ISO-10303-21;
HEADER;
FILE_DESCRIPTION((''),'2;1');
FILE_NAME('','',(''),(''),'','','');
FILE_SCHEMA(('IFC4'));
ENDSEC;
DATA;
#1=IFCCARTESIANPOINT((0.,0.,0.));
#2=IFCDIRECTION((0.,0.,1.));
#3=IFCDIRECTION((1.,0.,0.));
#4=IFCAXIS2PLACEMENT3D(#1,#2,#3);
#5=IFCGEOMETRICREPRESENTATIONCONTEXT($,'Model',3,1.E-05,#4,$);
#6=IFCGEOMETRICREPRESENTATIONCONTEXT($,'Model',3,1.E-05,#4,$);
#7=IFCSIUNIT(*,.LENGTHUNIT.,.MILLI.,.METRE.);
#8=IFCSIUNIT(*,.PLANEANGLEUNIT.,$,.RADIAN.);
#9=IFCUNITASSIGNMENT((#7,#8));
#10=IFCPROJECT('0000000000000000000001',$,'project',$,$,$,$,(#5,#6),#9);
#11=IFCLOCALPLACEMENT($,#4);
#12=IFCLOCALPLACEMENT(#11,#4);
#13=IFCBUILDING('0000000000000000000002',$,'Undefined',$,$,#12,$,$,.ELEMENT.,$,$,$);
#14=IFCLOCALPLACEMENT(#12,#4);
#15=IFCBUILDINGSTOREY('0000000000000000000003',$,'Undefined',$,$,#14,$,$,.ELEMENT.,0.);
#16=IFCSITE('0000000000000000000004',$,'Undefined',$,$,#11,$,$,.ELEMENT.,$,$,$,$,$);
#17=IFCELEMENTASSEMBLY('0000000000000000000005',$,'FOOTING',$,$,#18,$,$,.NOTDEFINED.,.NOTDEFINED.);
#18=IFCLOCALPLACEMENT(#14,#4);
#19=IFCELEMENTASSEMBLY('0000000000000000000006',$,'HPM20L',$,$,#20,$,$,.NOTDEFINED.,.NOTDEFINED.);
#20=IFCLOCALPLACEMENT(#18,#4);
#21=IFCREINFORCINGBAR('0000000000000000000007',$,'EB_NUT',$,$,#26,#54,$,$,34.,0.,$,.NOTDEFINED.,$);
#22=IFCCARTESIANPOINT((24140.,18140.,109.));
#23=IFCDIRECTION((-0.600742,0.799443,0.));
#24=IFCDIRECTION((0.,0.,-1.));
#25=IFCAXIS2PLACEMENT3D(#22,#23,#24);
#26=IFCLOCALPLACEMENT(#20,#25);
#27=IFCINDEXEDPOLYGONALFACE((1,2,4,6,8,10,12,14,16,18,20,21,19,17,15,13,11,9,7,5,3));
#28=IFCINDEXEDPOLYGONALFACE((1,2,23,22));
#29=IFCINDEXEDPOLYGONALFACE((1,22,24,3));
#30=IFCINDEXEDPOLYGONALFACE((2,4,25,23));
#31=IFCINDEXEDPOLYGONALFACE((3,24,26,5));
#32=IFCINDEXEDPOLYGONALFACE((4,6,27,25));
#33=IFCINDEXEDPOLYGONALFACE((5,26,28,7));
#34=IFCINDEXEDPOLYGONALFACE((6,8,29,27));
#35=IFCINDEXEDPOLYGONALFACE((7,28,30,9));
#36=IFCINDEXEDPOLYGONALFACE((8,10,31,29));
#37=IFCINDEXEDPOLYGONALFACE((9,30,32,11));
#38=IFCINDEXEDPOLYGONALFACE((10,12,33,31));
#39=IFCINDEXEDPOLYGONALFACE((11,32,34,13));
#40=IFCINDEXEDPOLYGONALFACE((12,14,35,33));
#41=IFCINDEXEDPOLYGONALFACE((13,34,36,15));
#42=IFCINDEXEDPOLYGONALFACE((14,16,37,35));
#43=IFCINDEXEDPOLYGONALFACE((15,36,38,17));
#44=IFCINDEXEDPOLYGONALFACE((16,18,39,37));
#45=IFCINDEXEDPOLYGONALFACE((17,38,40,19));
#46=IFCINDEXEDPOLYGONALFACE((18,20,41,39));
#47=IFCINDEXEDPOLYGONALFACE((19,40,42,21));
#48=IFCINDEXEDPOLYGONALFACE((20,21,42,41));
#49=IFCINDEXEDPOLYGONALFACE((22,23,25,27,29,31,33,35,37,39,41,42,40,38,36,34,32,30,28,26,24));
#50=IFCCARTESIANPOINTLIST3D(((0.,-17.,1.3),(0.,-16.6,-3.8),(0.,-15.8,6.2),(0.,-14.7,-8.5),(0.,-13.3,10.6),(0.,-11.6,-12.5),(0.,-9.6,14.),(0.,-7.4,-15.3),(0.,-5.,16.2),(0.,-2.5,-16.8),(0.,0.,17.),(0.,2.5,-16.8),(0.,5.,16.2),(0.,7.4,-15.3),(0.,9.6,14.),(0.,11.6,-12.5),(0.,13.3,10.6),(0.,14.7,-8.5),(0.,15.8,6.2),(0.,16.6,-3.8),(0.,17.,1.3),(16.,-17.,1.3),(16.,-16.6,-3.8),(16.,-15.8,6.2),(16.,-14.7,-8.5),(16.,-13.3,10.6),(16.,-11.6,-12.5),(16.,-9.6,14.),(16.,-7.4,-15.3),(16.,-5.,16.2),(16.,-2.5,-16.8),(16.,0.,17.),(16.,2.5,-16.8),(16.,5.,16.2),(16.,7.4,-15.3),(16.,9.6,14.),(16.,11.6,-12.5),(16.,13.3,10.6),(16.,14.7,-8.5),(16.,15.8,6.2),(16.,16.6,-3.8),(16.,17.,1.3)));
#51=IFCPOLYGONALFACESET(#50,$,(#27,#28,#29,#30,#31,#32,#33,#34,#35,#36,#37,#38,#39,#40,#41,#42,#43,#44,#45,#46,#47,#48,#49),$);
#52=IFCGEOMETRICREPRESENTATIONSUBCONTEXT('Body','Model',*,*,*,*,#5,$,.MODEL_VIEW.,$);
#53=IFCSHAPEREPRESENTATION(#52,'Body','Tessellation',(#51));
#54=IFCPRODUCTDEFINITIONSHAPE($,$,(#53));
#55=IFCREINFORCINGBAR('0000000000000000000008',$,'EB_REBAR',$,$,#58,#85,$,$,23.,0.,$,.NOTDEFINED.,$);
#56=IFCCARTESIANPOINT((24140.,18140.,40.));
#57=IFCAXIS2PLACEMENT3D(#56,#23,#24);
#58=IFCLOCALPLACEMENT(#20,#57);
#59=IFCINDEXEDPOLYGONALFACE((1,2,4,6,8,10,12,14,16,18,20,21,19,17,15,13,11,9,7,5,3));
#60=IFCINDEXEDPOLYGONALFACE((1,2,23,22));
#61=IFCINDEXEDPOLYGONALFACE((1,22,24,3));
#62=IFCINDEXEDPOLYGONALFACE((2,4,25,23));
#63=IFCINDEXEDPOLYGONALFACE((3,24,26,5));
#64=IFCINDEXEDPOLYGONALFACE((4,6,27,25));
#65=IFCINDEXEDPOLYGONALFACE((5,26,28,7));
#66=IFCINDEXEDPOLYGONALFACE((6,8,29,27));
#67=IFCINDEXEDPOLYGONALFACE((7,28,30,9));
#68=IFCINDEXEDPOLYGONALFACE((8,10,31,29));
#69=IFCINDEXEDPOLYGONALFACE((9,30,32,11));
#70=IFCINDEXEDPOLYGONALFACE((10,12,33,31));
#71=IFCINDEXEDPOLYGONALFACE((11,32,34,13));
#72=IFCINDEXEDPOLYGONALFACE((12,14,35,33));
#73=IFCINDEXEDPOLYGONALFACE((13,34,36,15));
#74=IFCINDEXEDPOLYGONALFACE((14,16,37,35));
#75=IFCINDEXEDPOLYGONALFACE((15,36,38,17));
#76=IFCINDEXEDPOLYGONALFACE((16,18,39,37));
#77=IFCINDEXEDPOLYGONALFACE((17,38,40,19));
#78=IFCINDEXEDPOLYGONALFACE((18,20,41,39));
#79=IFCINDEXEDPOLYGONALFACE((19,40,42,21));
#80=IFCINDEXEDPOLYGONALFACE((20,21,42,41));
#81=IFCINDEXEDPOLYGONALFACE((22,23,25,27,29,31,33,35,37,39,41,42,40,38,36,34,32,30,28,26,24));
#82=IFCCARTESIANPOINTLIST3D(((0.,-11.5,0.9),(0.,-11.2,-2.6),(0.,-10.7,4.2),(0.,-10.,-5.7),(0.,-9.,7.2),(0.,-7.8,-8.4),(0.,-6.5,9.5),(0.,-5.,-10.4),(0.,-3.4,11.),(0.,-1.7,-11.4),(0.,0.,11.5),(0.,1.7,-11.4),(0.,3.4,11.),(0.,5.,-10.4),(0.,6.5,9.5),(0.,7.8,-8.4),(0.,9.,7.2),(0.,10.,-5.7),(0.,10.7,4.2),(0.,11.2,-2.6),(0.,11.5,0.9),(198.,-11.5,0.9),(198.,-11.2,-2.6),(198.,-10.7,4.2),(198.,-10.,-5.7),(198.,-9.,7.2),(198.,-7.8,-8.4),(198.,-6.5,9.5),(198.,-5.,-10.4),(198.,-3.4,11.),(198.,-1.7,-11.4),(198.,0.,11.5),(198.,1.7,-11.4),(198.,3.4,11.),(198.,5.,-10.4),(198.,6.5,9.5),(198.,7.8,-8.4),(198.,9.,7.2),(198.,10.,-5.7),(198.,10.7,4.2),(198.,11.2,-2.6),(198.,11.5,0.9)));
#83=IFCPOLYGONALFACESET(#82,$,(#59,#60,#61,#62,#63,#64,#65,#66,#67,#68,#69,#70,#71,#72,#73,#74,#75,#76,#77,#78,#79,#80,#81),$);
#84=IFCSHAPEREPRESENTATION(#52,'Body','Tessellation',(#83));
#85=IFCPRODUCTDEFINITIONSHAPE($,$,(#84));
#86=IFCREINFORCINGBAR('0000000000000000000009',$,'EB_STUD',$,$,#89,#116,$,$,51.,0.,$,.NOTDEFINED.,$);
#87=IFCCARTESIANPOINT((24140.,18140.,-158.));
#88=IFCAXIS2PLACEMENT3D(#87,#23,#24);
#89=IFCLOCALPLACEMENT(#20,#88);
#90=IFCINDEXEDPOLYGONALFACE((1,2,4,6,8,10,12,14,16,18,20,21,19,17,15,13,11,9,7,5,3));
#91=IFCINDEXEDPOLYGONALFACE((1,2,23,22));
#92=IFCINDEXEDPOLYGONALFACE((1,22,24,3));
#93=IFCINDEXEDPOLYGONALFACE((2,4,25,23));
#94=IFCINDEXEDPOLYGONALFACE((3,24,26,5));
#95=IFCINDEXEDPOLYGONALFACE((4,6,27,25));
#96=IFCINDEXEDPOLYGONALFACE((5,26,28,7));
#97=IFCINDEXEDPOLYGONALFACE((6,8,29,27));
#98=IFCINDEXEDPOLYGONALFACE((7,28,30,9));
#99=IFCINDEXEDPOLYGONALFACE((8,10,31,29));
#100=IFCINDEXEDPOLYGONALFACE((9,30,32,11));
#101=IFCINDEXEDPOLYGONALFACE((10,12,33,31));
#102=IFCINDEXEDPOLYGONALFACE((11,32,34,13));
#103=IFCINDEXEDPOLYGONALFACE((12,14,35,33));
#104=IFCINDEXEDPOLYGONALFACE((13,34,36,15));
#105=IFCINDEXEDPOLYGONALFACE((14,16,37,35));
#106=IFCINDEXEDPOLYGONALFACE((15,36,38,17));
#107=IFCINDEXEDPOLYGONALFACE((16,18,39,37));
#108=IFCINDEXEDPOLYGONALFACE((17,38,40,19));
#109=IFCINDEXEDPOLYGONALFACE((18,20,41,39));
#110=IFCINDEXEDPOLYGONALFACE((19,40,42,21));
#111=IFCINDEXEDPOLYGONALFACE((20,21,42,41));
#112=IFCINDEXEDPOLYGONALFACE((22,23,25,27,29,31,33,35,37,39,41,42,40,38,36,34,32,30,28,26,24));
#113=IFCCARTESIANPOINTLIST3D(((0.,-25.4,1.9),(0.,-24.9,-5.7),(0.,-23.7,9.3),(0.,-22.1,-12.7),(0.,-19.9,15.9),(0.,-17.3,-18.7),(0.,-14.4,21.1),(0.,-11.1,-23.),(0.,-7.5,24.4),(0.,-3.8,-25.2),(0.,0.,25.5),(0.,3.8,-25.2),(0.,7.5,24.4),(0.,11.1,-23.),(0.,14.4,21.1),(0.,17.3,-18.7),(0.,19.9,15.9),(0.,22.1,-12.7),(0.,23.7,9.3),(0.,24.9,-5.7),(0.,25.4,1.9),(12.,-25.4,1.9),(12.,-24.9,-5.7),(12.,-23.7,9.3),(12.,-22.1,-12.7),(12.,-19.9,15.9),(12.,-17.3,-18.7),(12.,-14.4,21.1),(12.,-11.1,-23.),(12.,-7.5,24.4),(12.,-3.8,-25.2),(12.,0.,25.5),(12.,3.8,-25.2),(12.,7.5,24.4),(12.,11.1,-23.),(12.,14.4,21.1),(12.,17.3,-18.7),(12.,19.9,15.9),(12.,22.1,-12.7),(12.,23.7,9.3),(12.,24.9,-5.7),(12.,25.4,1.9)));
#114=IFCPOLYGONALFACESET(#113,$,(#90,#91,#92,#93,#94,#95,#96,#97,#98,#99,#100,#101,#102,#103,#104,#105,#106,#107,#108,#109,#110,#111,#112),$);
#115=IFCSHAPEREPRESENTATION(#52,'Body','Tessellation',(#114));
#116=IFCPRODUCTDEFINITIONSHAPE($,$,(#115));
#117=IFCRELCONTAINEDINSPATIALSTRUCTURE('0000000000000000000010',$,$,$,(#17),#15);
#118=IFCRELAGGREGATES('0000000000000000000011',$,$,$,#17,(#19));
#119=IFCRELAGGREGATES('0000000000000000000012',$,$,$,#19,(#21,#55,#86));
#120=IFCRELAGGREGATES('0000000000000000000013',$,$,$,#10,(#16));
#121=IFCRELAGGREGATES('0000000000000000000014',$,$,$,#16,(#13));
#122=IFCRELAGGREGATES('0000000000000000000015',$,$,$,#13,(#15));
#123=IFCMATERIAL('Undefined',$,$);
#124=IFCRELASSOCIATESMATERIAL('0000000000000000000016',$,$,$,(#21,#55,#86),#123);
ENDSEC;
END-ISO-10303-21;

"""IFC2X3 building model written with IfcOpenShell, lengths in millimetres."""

from ifc_helpers import new_model, entity, si_unit, frame, origin_with_axes, place, context, subcontext, project, spatial, source, transform, mapped, material, element, aggregate, save


model = new_model("IFC2X3")

# Units and contexts
model_context_1 = context("Model", 3, precision=1e-05, world=origin_with_axes())
model_context_2 = context("Model", 3, precision=1e-05, world=origin_with_axes())
body_context = subcontext(model_context_1, "Body", "Model", "MODEL_VIEW")
ifc_project = project(units=[si_unit("LENGTHUNIT", "METRE", prefix="MILLI"), si_unit("PLANEANGLEUNIT", "RADIAN")], contexts=[model_context_1, model_context_2])

# Site, building, storey
site_placement = place(None, origin_with_axes())
site = spatial("IfcSite", under=ifc_project, at=site_placement, Name="Undefined", CompositionType="ELEMENT")
building_placement = place(site_placement, origin_with_axes())
building = spatial("IfcBuilding", under=site, at=building_placement, Name="Undefined", CompositionType="ELEMENT")
storey_placement = place(building_placement, origin_with_axes())
storey = spatial("IfcBuildingStorey", under=building, at=storey_placement, Name="Undefined", CompositionType="ELEMENT", Elevation=0.0)

# Element assembly
assembly_1_placement = place(storey_placement, origin_with_axes())
assembly_1 = element("IfcElementAssembly", 1, at=assembly_1_placement, inside=storey, Name="FOOTING", AssemblyPlace="NOTDEFINED", PredefinedType="NOTDEFINED")

# Shared definitions
ifc_material_1 = material(Name="Undefined")

# Element assembly
assembly_2_placement = place(assembly_1_placement, origin_with_axes())
assembly_2 = element("IfcElementAssembly", 2, at=assembly_2_placement, Name="HPM20L", AssemblyPlace="NOTDEFINED", PredefinedType="NOTDEFINED")
aggregate(assembly_1, [assembly_2])

# Reinforcing bars
shared_shape_1 = source(origin_with_axes(), body_context, "Body", "AdvancedSweptSolid", [
    entity("IfcSweptDiskSolid", entity("IfcTrimmedCurve", entity("IfcLine", entity("IfcCartesianPoint", [0.0, 0.0, 0.0]), entity("IfcVector", entity("IfcDirection", [1.0, 0.0, 0.0]), 1.0)), [entity("IfcParameterValue", 0.0)], [entity("IfcParameterValue", 16.0)], True, "PARAMETER"), 17.0, None, 0.0, 16.0),
])
reinforcing_bar_1_placement = place(assembly_2_placement, frame((24140.0, 18140.0, 109.0), z_axis=(-0.600742, 0.799443, 0.0), x_axis=(0.0, 0.0, -1.0)))
reinforcing_bar_1 = element("IfcReinforcingBar", 3, at=reinforcing_bar_1_placement, material=ifc_material_1, Name="EB_NUT", BarRole="NOTDEFINED", CrossSectionArea=0.0, NominalDiameter=34.0, context=body_context, shape_type="MappedRepresentation", body=[
    mapped(shared_shape_1, transform((0.0, 0.0, 0.0))),
])
shared_shape_2 = source(origin_with_axes(), body_context, "Body", "AdvancedSweptSolid", [
    entity("IfcSweptDiskSolid", entity("IfcTrimmedCurve", entity("IfcLine", entity("IfcCartesianPoint", [0.0, 0.0, 0.0]), entity("IfcVector", entity("IfcDirection", [1.0, 0.0, 0.0]), 1.0)), [entity("IfcParameterValue", 0.0)], [entity("IfcParameterValue", 198.0)], True, "PARAMETER"), 11.5, None, 0.0, 198.0),
])
reinforcing_bar_2_placement = place(assembly_2_placement, frame((24140.0, 18140.0, 40.0), z_axis=(-0.600742, 0.799443, 0.0), x_axis=(0.0, 0.0, -1.0)))
reinforcing_bar_2 = element("IfcReinforcingBar", 4, at=reinforcing_bar_2_placement, material=ifc_material_1, Name="EB_REBAR", BarRole="NOTDEFINED", CrossSectionArea=0.0, NominalDiameter=23.0, context=body_context, shape_type="MappedRepresentation", body=[
    mapped(shared_shape_2, transform((0.0, 0.0, 0.0))),
])
shared_shape_3 = source(origin_with_axes(), body_context, "Body", "AdvancedSweptSolid", [
    entity("IfcSweptDiskSolid", entity("IfcTrimmedCurve", entity("IfcLine", entity("IfcCartesianPoint", [0.0, 0.0, 0.0]), entity("IfcVector", entity("IfcDirection", [1.0, 0.0, 0.0]), 1.0)), [entity("IfcParameterValue", 0.0)], [entity("IfcParameterValue", 12.0)], True, "PARAMETER"), 25.5, None, 0.0, 12.0),
])
reinforcing_bar_3_placement = place(assembly_2_placement, frame((24140.0, 18140.0, -158.0), z_axis=(-0.600742, 0.799443, 0.0), x_axis=(0.0, 0.0, -1.0)))
reinforcing_bar_3 = element("IfcReinforcingBar", 5, at=reinforcing_bar_3_placement, material=ifc_material_1, Name="EB_STUD", BarRole="NOTDEFINED", CrossSectionArea=0.0, NominalDiameter=51.0, context=body_context, shape_type="MappedRepresentation", body=[
    mapped(shared_shape_3, transform((0.0, 0.0, 0.0))),
])
aggregate(assembly_2, [reinforcing_bar_1, reinforcing_bar_2, reinforcing_bar_3])

save(model, "model.ifc")
